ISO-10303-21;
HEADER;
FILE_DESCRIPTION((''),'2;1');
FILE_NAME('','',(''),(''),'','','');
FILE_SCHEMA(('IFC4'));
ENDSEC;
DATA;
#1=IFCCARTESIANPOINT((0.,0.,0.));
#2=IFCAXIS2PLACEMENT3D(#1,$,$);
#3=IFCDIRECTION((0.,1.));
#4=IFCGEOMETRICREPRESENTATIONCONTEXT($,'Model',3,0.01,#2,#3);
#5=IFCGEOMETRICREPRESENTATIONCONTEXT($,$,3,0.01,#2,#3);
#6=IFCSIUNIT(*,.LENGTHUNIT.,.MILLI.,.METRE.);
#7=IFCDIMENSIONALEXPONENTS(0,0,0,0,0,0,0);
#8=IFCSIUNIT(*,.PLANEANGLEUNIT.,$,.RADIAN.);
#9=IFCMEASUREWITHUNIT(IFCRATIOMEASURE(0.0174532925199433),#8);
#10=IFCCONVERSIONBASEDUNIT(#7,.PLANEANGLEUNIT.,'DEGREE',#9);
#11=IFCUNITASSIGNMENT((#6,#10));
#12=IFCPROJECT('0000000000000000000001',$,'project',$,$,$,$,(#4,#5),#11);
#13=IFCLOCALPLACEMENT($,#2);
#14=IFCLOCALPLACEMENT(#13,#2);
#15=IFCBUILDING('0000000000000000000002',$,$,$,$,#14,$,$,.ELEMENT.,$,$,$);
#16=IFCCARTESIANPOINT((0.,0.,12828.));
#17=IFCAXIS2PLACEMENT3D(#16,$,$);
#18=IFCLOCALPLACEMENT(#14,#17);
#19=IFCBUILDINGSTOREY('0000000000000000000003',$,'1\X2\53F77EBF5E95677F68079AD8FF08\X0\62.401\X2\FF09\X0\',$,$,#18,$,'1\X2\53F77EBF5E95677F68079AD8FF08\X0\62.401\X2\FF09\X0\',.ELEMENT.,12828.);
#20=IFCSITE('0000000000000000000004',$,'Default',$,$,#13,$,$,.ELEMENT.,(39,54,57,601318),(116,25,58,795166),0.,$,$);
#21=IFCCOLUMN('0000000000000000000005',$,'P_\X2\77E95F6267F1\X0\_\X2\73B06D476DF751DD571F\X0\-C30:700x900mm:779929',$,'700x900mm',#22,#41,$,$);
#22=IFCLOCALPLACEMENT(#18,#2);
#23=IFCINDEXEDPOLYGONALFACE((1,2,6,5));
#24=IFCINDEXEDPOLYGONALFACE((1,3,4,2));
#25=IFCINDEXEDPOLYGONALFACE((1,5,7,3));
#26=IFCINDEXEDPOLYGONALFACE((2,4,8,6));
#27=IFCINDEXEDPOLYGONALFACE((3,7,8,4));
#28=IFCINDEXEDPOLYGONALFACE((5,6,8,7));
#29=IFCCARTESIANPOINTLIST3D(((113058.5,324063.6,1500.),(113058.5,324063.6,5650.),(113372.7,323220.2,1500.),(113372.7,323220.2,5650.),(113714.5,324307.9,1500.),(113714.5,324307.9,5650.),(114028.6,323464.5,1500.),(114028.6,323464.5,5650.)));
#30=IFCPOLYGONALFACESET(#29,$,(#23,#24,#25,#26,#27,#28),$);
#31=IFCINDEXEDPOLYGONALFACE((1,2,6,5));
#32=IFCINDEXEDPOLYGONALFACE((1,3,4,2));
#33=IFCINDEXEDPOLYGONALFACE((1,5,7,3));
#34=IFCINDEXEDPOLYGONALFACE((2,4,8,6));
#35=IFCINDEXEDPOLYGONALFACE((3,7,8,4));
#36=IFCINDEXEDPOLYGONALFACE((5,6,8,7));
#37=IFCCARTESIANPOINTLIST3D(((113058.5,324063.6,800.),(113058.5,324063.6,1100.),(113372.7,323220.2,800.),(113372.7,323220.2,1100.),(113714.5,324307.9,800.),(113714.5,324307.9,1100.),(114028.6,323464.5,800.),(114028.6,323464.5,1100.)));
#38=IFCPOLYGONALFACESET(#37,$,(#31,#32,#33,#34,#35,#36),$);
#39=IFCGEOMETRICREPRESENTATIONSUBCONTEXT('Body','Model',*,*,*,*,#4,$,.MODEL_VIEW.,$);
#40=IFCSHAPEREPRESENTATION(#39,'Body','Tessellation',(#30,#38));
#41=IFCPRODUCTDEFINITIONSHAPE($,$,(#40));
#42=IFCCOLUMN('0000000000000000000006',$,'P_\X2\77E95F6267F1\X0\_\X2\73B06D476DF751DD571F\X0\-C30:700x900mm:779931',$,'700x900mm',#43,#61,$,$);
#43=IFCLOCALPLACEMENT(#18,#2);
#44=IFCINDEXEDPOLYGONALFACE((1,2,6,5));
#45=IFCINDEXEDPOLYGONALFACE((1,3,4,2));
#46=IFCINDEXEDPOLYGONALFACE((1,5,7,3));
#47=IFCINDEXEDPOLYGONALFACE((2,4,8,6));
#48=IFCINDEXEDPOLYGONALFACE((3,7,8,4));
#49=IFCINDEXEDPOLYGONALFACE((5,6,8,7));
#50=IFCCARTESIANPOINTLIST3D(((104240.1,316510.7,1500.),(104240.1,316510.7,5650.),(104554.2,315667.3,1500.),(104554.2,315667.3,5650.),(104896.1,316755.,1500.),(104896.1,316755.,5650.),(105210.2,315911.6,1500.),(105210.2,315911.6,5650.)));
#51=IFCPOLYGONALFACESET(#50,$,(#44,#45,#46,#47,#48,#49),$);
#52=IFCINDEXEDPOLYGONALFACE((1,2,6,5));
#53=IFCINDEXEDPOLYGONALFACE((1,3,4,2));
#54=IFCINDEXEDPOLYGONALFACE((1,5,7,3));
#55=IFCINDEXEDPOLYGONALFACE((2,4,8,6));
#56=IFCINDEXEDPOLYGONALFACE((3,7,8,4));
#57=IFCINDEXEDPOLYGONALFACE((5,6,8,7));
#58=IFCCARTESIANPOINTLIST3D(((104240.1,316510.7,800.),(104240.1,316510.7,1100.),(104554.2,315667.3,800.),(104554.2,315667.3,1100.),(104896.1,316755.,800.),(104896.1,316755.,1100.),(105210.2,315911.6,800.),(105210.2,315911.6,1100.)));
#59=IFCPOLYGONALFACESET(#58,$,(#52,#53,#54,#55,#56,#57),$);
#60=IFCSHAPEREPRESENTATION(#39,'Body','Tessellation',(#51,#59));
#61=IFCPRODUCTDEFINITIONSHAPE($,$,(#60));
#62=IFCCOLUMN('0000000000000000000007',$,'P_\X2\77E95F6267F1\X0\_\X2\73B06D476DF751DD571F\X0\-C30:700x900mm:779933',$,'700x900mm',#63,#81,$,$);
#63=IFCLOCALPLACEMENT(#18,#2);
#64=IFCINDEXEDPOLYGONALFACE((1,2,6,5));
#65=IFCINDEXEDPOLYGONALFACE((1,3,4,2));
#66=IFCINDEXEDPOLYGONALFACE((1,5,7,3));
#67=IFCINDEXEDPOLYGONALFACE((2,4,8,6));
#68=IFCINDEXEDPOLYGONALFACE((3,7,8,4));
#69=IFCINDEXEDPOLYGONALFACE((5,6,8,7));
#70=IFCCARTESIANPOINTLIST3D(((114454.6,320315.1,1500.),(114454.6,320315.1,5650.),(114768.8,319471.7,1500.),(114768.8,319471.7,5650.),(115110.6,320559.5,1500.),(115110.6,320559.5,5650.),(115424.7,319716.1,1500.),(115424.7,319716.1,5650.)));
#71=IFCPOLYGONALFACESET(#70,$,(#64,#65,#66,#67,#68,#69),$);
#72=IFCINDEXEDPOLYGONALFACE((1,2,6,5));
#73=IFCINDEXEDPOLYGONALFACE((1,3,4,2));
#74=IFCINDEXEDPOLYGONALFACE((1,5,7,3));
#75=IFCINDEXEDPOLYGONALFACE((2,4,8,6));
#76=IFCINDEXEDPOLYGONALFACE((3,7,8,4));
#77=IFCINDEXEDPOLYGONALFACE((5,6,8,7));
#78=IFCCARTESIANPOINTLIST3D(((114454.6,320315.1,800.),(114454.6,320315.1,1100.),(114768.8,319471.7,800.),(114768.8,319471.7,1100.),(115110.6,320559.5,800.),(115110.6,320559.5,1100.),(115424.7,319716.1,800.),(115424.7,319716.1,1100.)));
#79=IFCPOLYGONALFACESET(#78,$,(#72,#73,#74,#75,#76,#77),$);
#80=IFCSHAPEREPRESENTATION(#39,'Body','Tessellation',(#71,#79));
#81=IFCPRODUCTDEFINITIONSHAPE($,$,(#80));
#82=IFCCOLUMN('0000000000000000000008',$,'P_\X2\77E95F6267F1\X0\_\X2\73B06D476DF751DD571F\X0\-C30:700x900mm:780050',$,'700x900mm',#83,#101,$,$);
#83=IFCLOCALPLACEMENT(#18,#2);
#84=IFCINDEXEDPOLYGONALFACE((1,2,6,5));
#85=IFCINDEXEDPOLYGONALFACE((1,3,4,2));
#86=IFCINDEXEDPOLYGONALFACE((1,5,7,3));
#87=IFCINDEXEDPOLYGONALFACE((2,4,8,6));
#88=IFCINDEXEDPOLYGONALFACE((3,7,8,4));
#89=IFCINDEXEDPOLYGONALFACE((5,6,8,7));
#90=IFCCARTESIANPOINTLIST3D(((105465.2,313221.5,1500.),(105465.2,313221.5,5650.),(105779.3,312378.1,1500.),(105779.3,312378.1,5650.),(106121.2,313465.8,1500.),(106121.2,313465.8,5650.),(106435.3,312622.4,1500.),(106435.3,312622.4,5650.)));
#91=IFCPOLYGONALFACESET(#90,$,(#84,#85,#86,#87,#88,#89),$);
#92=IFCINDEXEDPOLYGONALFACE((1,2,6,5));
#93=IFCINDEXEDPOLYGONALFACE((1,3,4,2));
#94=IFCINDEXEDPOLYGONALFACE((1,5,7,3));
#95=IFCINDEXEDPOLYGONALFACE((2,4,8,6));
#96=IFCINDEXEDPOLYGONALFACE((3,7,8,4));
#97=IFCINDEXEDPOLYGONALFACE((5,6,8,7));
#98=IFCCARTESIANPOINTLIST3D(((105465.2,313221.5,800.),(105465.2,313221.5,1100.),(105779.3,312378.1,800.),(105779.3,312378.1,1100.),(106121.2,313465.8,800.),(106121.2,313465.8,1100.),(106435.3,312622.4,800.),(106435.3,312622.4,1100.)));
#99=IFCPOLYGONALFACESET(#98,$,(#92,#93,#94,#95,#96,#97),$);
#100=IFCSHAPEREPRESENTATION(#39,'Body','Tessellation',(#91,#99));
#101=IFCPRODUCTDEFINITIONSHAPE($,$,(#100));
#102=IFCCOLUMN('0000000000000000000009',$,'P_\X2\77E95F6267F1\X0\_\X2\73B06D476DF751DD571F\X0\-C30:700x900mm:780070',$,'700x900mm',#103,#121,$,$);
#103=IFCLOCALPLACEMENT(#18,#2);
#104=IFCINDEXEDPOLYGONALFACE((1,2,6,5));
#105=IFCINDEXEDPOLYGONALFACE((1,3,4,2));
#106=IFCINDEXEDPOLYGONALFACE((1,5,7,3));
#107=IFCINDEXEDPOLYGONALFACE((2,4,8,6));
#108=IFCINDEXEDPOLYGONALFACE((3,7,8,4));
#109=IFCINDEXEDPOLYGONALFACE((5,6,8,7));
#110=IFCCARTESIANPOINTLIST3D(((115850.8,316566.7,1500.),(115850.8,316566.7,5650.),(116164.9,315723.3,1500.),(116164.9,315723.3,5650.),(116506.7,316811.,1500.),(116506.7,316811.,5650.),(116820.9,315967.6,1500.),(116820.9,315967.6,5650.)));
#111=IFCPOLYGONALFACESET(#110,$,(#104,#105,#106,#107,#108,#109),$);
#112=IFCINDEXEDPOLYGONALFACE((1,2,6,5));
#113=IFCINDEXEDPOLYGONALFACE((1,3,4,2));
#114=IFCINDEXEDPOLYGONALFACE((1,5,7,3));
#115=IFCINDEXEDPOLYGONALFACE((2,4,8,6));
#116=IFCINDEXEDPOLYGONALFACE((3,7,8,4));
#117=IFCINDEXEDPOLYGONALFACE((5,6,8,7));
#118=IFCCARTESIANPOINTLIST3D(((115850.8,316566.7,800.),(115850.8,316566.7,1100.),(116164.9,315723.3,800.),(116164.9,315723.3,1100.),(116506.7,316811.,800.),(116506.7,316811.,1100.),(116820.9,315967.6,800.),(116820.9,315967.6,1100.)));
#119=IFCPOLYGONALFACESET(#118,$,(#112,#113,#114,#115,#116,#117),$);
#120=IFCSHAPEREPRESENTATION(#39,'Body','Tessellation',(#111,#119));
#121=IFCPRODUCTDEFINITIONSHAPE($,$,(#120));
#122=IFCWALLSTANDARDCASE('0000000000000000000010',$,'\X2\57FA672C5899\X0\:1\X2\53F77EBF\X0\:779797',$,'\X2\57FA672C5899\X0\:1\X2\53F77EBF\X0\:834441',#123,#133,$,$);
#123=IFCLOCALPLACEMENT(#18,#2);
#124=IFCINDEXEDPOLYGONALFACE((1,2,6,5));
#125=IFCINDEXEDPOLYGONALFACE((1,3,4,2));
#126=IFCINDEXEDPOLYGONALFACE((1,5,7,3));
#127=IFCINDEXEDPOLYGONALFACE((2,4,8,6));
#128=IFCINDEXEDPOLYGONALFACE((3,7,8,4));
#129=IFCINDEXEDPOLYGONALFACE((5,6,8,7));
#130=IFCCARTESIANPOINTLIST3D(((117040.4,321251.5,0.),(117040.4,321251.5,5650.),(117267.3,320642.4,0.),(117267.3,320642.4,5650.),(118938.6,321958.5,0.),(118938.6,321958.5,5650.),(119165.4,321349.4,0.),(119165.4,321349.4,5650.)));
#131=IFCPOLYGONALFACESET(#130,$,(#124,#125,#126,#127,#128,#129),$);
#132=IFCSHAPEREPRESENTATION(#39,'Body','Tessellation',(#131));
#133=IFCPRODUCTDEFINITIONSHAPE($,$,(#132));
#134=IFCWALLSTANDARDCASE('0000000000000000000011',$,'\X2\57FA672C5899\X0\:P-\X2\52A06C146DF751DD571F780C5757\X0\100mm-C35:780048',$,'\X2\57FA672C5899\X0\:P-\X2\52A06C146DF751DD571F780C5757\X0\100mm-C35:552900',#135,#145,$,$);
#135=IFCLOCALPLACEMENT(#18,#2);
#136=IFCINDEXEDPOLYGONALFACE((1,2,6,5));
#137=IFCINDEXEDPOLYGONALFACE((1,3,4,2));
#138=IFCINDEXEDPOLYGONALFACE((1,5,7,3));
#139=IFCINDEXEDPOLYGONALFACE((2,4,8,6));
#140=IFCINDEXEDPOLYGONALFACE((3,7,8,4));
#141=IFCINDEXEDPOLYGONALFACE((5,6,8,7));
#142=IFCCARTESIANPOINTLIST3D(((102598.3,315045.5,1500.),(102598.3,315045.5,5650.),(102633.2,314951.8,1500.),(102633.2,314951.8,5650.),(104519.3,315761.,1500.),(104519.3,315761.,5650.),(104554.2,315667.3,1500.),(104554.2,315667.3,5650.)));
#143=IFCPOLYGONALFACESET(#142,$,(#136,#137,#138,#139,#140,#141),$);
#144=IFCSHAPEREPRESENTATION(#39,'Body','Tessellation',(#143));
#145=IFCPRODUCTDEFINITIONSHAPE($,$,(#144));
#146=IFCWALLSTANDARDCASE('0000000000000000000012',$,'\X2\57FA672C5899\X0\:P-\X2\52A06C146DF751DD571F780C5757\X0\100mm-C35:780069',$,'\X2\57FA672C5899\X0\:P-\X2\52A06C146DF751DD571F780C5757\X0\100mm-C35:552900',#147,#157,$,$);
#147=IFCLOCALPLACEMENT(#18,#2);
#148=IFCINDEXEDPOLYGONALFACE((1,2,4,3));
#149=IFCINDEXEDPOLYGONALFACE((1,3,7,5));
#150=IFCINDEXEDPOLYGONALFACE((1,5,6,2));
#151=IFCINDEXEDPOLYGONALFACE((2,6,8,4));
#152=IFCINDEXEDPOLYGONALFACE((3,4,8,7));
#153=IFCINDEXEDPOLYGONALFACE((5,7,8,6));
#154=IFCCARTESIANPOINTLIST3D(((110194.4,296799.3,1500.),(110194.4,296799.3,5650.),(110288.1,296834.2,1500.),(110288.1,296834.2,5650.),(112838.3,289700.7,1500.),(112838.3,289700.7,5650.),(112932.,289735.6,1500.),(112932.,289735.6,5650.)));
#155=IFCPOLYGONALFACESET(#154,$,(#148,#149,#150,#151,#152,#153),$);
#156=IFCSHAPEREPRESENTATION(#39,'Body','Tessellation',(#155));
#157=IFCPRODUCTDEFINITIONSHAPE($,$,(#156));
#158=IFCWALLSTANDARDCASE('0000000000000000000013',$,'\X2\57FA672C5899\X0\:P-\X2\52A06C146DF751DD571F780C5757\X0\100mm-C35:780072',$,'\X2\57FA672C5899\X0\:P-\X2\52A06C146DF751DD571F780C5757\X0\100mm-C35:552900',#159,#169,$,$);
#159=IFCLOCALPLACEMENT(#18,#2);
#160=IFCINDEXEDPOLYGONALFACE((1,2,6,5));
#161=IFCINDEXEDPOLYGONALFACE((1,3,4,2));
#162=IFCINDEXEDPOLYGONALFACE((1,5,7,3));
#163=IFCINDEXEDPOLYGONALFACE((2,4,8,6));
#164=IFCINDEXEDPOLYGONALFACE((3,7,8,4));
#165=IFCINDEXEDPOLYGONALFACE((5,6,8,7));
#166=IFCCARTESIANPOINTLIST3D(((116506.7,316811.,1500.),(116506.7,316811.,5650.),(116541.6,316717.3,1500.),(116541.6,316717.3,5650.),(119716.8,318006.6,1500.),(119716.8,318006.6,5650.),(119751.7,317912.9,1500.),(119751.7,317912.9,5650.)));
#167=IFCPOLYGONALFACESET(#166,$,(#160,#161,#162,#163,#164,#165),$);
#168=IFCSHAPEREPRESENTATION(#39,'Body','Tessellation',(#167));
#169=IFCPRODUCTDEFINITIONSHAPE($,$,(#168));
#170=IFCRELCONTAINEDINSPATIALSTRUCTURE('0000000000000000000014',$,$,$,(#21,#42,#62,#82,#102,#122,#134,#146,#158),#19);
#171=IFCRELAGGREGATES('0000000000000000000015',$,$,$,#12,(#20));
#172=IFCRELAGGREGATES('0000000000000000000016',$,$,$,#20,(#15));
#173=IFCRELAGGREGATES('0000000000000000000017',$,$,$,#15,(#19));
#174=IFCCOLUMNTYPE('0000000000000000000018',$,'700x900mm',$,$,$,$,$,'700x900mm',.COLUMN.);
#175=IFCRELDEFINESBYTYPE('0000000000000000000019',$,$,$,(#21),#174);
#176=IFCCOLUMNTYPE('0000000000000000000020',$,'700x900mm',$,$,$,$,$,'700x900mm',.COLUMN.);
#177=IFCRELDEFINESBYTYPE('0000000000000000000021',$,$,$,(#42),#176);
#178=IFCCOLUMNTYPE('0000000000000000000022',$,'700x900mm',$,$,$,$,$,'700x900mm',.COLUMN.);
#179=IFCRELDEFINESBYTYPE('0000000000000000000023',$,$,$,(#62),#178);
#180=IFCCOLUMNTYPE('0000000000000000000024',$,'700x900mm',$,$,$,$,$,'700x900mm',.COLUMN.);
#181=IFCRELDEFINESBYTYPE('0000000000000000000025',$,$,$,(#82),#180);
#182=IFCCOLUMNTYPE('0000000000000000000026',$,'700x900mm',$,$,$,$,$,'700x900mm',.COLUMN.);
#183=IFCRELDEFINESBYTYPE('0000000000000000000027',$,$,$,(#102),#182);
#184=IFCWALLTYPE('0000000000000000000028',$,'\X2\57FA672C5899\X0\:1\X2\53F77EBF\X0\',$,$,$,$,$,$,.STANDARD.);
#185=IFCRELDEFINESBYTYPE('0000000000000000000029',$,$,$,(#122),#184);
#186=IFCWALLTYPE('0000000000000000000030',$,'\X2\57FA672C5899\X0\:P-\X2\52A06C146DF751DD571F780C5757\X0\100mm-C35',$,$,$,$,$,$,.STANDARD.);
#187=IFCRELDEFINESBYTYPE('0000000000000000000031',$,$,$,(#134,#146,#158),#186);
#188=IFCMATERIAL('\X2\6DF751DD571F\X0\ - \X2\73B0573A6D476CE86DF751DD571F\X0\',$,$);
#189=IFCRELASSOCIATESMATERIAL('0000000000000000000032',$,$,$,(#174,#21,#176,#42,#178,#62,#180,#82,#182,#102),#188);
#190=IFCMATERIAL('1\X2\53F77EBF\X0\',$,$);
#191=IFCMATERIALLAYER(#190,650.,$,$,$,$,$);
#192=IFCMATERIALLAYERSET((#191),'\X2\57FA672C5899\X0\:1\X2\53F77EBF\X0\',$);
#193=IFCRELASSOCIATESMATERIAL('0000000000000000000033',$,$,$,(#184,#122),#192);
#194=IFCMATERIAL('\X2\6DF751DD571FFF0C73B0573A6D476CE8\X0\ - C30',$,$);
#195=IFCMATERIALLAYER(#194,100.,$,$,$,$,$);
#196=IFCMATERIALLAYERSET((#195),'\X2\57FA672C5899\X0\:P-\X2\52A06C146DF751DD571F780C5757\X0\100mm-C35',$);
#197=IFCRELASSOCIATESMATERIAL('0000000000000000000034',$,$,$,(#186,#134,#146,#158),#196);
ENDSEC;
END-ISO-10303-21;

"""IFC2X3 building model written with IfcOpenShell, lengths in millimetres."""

from ifc_helpers import new_model, entity, si_unit, converted_unit, direction, frame, frame_2d, origin, origin_2d_with_axis, place, context, subcontext, project, spatial, polyline, rectangle, extrude, clip, bounded_halfspace, source, transform, mapped, material, layer, layer_set, layer_usage, type_object, type_shapes, element, save


model = new_model("IFC2X3")

# Units and contexts
model_context = context("Model", 3, precision=0.01, world=origin(), true_north=direction((0.0, 1.0)))
context_of_model = context(None, 3, precision=0.01, world=origin(), true_north=direction((0.0, 1.0)))
body_context = subcontext(model_context, "Body", "Model", "MODEL_VIEW")
ifc_project = project(units=[si_unit("LENGTHUNIT", "METRE", prefix="MILLI"), converted_unit("PLANEANGLEUNIT", "DEGREE", entity("IfcRatioMeasure", 0.0174532925199433), si_unit("PLANEANGLEUNIT", "RADIAN"), dimensions=[0, 0, 0, 0, 0, 0, 0])], contexts=[model_context, context_of_model])

# Site, building, storey
site_placement = place(None, origin())
site = spatial("IfcSite", under=ifc_project, at=site_placement, Name="Default", CompositionType="ELEMENT", RefLatitude=(39, 54, 57, 601318), RefLongitude=(116, 25, 58, 795166), RefElevation=0.0)
building_placement = place(site_placement, origin())
building = spatial("IfcBuilding", under=site, at=building_placement, CompositionType="ELEMENT")
storey_placement = place(building_placement, frame((0.0, 0.0, 12828.0)))
storey = spatial("IfcBuildingStorey", under=building, at=storey_placement, Name="1号线底板标高（62.401）", LongName="1号线底板标高（62.401）", CompositionType="ELEMENT", Elevation=12828.0)

# Columns
ifc_material_1 = material(Name="混凝土 - 现场浇注混凝土")
column_type_1 = type_object("IfcColumnType", Name="700x900mm", ElementType="700x900mm", PredefinedType="COLUMN", material=ifc_material_1)
shared_shape_1 = source(origin(), body_context, "Body", "SweptSolid", [
    extrude(rectangle(XDim=900.0, YDim=700.0, at=frame_2d((86.0, 70.0), x_axis=(1.0, 0.0))), frame((389.4, 600.0, 700.0), z_axis=(0.0, 0.0, 1.0), x_axis=(0.349028, -0.937112, 0.0)), (0.0, 0.0, 1.0), 4150.0),
    extrude(rectangle(XDim=900.0, YDim=700.0, at=frame_2d((0.0, 0.0), x_axis=(1.0, 0.0))), frame((485.1, 543.9, 0.0), z_axis=(0.0, 0.0, 1.0), x_axis=(0.349028, -0.937112, 0.0)), (0.0, 0.0, 1.0), 300.0),
])
type_shapes(column_type_1, [shared_shape_1])
column_1_placement = place(storey_placement, frame((113058.5, 323220.2, 800.0)))
element("IfcColumn", 1, at=column_1_placement, inside=storey, type_object=column_type_1, material=ifc_material_1, Name="P_矩形柱_现浇混凝土-C30:700x900mm:779929", ObjectType="700x900mm", context=body_context, shape_type="MappedRepresentation", body=[
    mapped(shared_shape_1, transform((0.0, 0.0, 0.0), scale=1.0)),
])
column_type_2 = type_object("IfcColumnType", Name="700x900mm", ElementType="700x900mm", PredefinedType="COLUMN", material=ifc_material_1)
shared_shape_2 = source(origin(), body_context, "Body", "SweptSolid", [
    extrude(rectangle(XDim=700.0, YDim=900.0, at=origin_2d_with_axis()), frame((485.1, 543.9, 700.0), z_axis=(0.0, 0.0, 1.0), x_axis=(-0.937112, -0.349028, 0.0)), (0.0, 0.0, 1.0), 4150.0),
    extrude(rectangle(XDim=700.0, YDim=900.0, at=origin_2d_with_axis()), frame((485.1, 543.9, 0.0), z_axis=(0.0, 0.0, 1.0), x_axis=(-0.937112, -0.349028, 0.0)), (0.0, 0.0, 1.0), 300.0),
])
type_shapes(column_type_2, [shared_shape_2])
column_2_placement = place(storey_placement, frame((104240.1, 315667.3, 800.0)))
element("IfcColumn", 2, at=column_2_placement, inside=storey, type_object=column_type_2, material=ifc_material_1, Name="P_矩形柱_现浇混凝土-C30:700x900mm:779931", ObjectType="700x900mm", context=body_context, shape_type="MappedRepresentation", body=[
    mapped(shared_shape_2, transform((0.0, 0.0, 0.0), scale=1.0)),
])
column_type_3 = type_object("IfcColumnType", Name="700x900mm", ElementType="700x900mm", PredefinedType="COLUMN", material=ifc_material_1)
shared_shape_3 = source(origin(), body_context, "Body", "SweptSolid", [
    extrude(rectangle(XDim=700.0, YDim=900.0, at=frame_2d((0.0, 0.0), x_axis=(1.0, 0.0))), frame((485.1, 543.9, 700.0), z_axis=(0.0, 0.0, 1.0), x_axis=(-0.937112, -0.349028, 0.0)), (0.0, 0.0, 1.0), 4150.0),
    extrude(rectangle(XDim=700.0, YDim=900.0, at=frame_2d((0.0, 0.0), x_axis=(1.0, 0.0))), frame((485.1, 543.9, 0.0), z_axis=(0.0, 0.0, 1.0), x_axis=(-0.937112, -0.349028, 0.0)), (0.0, 0.0, 1.0), 300.0),
])
type_shapes(column_type_3, [shared_shape_3])
column_3_placement = place(storey_placement, frame((114454.6, 319471.7, 800.0)))
element("IfcColumn", 3, at=column_3_placement, inside=storey, type_object=column_type_3, material=ifc_material_1, Name="P_矩形柱_现浇混凝土-C30:700x900mm:779933", ObjectType="700x900mm", context=body_context, shape_type="MappedRepresentation", body=[
    mapped(shared_shape_3, transform((0.0, 0.0, 0.0), scale=1.0)),
])
column_type_4 = type_object("IfcColumnType", Name="700x900mm", ElementType="700x900mm", PredefinedType="COLUMN", material=ifc_material_1)
shared_shape_4 = source(origin(), body_context, "Body", "SweptSolid", [
    extrude(rectangle(XDim=700.0, YDim=900.0, at=frame_2d((0.0, 0.0), x_axis=(1.0, 0.0))), frame((485.1, 543.9, 700.0), z_axis=(0.0, 0.0, 1.0), x_axis=(-0.937112, -0.349028, 0.0)), (0.0, 0.0, 1.0), 4150.0),
    extrude(rectangle(XDim=700.0, YDim=900.0, at=frame_2d((0.0, 0.0), x_axis=(1.0, 0.0))), frame((485.1, 543.9, 0.0), z_axis=(0.0, 0.0, 1.0), x_axis=(-0.937112, -0.349028, 0.0)), (0.0, 0.0, 1.0), 300.0),
])
type_shapes(column_type_4, [shared_shape_4])
column_4_placement = place(storey_placement, frame((105465.2, 312378.1, 800.0)))
element("IfcColumn", 4, at=column_4_placement, inside=storey, type_object=column_type_4, material=ifc_material_1, Name="P_矩形柱_现浇混凝土-C30:700x900mm:780050", ObjectType="700x900mm", context=body_context, shape_type="MappedRepresentation", body=[
    mapped(shared_shape_4, transform((0.0, 0.0, 0.0), scale=1.0)),
])
column_type_5 = type_object("IfcColumnType", Name="700x900mm", ElementType="700x900mm", PredefinedType="COLUMN", material=ifc_material_1)
shared_shape_5 = source(origin(), body_context, "Body", "SweptSolid", [
    extrude(rectangle(XDim=700.0, YDim=900.0, at=frame_2d((0.0, 0.0), x_axis=(1.0, 0.0))), frame((485.1, 543.9, 700.0), z_axis=(0.0, 0.0, 1.0), x_axis=(-0.937112, -0.349028, 0.0)), (0.0, 0.0, 1.0), 4150.0),
    extrude(rectangle(XDim=700.0, YDim=900.0, at=frame_2d((0.0, 0.0), x_axis=(1.0, 0.0))), frame((485.1, 543.9, 0.0), z_axis=(0.0, 0.0, 1.0), x_axis=(-0.937112, -0.349028, 0.0)), (0.0, 0.0, 1.0), 300.0),
])
type_shapes(column_type_5, [shared_shape_5])
column_5_placement = place(storey_placement, frame((115850.8, 315723.3, 800.0)))
element("IfcColumn", 5, at=column_5_placement, inside=storey, type_object=column_type_5, material=ifc_material_1, Name="P_矩形柱_现浇混凝土-C30:700x900mm:780070", ObjectType="700x900mm", context=body_context, shape_type="MappedRepresentation", body=[
    mapped(shared_shape_5, transform((0.0, 0.0, 0.0), scale=1.0)),
])

# Walls
ifc_material_2 = material(Name="1号线")
ifc_layer_1 = layer(ifc_material_2, 650.0)
ifc_layer_set_1 = layer_set([ifc_layer_1], Name="基本墙:1号线")
ifc_layer_usage_1 = layer_usage(ifc_layer_set_1, "AXIS2", "NEGATIVE", 325.0)
wall_type_1 = type_object("IfcWallType", Name="基本墙:1号线", PredefinedType="STANDARD", material=ifc_layer_set_1)
wall_1_placement = place(storey_placement, frame((117153.9, 320947.0, 0.0), z_axis=(0.0, 0.0, 1.0), x_axis=(0.937112, 0.349028, 0.0)))
element("IfcWallStandardCase", 6, at=wall_1_placement, inside=storey, type_object=wall_type_1, material=ifc_layer_usage_1, Name="基本墙:1号线:779797", ObjectType="基本墙:1号线:834441", context=body_context, shape_type="Clipping", body=[
    clip(extrude(rectangle(XDim=2025.5, YDim=650.0, at=frame_2d((1012.8, 0.0), x_axis=(-1.0, 0.0))), origin(), (0.0, 0.0, 1.0), 5650.0), bounded_halfspace(frame((0.0, -325.0, 5650.0), z_axis=(0.0, 0.0, -1.0), x_axis=(1.0, 0.0, 0.0)), True, frame((0.0, -325.0, 5650.0)), polyline([(0.0, 0.0), (1375.5, 0.0), (2025.5, 0.0), (2025.5, 650.0), (1175.0, 650.0), (650.0, 650.0), (0.0, 650.0), (0.0, 0.0)]))),
])
ifc_material_3 = material(Name="混凝土，现场浇注 - C30")
ifc_layer_2 = layer(ifc_material_3, 100.0)
ifc_layer_set_2 = layer_set([ifc_layer_2], Name="基本墙:P-加气混凝土砌块100mm-C35")
ifc_layer_usage_2 = layer_usage(ifc_layer_set_2, "AXIS2", "NEGATIVE", 50.0)
wall_type_2 = type_object("IfcWallType", Name="基本墙:P-加气混凝土砌块100mm-C35", PredefinedType="STANDARD", material=ifc_layer_set_2)
wall_2_placement = place(storey_placement, frame((104536.8, 315714.2, 1500.0), z_axis=(0.0, 0.0, 1.0), x_axis=(-0.937112, -0.349028, 0.0)))
element("IfcWallStandardCase", 7, at=wall_2_placement, inside=storey, type_object=wall_type_2, material=ifc_layer_usage_2, Name="基本墙:P-加气混凝土砌块100mm-C35:780048", ObjectType="基本墙:P-加气混凝土砌块100mm-C35:552900", context=body_context, shape_type="Clipping", body=[
    clip(extrude(rectangle(XDim=2050.0, YDim=100.0, at=frame_2d((1025.0, 0.0), x_axis=(-1.0, 0.0))), origin(), (0.0, 0.0, 1.0), 4150.0), bounded_halfspace(frame((0.0, -50.0, 4150.0), z_axis=(0.0, 0.0, -1.0), x_axis=(-1.0, 0.0, 0.0)), True, frame((0.0, -50.0, 4150.0)), polyline([(0.0, 0.0), (2050.0, 0.0), (2050.0, 100.0), (0.0, 100.0), (0.0, 0.0)]))),
])
ifc_layer_usage_3 = layer_usage(ifc_layer_set_2, "AXIS2", "NEGATIVE", 50.0)
wall_3_placement = place(storey_placement, frame((110241.3, 296816.8, 1500.0), z_axis=(0.0, 0.0, 1.0), x_axis=(0.349028, -0.937112, 0.0)))
element("IfcWallStandardCase", 8, at=wall_3_placement, inside=storey, type_object=wall_type_2, material=ifc_layer_usage_3, Name="基本墙:P-加气混凝土砌块100mm-C35:780069", ObjectType="基本墙:P-加气混凝土砌块100mm-C35:552900", context=body_context, shape_type="Clipping", body=[
    clip(extrude(rectangle(XDim=7575.0, YDim=100.0, at=frame_2d((3787.5, 0.0), x_axis=(-1.0, 0.0))), origin(), (0.0, 0.0, 1.0), 4150.0), bounded_halfspace(frame((0.0, -50.0, 4150.0), z_axis=(0.0, 0.0, -1.0), x_axis=(0.0, 1.0, 0.0)), True, frame((0.0, -50.0, 4150.0)), polyline([(0.0, 0.0), (7575.0, 0.0), (7575.0, 100.0), (0.0, 100.0), (0.0, 0.0)]))),
])
ifc_layer_usage_4 = layer_usage(ifc_layer_set_2, "AXIS2", "NEGATIVE", 50.0)
wall_4_placement = place(storey_placement, frame((116524.2, 316764.1, 1500.0), z_axis=(0.0, 0.0, 1.0), x_axis=(0.937112, 0.349028, 0.0)))
element("IfcWallStandardCase", 9, at=wall_4_placement, inside=storey, type_object=wall_type_2, material=ifc_layer_usage_4, Name="基本墙:P-加气混凝土砌块100mm-C35:780072", ObjectType="基本墙:P-加气混凝土砌块100mm-C35:552900", context=body_context, shape_type="Clipping", body=[
    clip(extrude(rectangle(XDim=3425.5, YDim=100.0, at=frame_2d((1712.8, 0.0), x_axis=(-1.0, 0.0))), origin(), (0.0, 0.0, 1.0), 4150.0), bounded_halfspace(frame((0.0, -50.0, 4150.0), z_axis=(0.0, 0.0, -1.0), x_axis=(1.0, 0.0, 0.0)), True, frame((0.0, -50.0, 4150.0)), polyline([(0.0, 0.0), (3425.5, 0.0), (3425.5, 100.0), (0.0, 100.0), (0.0, 0.0)]))),
])

save(model, "model.ifc")
